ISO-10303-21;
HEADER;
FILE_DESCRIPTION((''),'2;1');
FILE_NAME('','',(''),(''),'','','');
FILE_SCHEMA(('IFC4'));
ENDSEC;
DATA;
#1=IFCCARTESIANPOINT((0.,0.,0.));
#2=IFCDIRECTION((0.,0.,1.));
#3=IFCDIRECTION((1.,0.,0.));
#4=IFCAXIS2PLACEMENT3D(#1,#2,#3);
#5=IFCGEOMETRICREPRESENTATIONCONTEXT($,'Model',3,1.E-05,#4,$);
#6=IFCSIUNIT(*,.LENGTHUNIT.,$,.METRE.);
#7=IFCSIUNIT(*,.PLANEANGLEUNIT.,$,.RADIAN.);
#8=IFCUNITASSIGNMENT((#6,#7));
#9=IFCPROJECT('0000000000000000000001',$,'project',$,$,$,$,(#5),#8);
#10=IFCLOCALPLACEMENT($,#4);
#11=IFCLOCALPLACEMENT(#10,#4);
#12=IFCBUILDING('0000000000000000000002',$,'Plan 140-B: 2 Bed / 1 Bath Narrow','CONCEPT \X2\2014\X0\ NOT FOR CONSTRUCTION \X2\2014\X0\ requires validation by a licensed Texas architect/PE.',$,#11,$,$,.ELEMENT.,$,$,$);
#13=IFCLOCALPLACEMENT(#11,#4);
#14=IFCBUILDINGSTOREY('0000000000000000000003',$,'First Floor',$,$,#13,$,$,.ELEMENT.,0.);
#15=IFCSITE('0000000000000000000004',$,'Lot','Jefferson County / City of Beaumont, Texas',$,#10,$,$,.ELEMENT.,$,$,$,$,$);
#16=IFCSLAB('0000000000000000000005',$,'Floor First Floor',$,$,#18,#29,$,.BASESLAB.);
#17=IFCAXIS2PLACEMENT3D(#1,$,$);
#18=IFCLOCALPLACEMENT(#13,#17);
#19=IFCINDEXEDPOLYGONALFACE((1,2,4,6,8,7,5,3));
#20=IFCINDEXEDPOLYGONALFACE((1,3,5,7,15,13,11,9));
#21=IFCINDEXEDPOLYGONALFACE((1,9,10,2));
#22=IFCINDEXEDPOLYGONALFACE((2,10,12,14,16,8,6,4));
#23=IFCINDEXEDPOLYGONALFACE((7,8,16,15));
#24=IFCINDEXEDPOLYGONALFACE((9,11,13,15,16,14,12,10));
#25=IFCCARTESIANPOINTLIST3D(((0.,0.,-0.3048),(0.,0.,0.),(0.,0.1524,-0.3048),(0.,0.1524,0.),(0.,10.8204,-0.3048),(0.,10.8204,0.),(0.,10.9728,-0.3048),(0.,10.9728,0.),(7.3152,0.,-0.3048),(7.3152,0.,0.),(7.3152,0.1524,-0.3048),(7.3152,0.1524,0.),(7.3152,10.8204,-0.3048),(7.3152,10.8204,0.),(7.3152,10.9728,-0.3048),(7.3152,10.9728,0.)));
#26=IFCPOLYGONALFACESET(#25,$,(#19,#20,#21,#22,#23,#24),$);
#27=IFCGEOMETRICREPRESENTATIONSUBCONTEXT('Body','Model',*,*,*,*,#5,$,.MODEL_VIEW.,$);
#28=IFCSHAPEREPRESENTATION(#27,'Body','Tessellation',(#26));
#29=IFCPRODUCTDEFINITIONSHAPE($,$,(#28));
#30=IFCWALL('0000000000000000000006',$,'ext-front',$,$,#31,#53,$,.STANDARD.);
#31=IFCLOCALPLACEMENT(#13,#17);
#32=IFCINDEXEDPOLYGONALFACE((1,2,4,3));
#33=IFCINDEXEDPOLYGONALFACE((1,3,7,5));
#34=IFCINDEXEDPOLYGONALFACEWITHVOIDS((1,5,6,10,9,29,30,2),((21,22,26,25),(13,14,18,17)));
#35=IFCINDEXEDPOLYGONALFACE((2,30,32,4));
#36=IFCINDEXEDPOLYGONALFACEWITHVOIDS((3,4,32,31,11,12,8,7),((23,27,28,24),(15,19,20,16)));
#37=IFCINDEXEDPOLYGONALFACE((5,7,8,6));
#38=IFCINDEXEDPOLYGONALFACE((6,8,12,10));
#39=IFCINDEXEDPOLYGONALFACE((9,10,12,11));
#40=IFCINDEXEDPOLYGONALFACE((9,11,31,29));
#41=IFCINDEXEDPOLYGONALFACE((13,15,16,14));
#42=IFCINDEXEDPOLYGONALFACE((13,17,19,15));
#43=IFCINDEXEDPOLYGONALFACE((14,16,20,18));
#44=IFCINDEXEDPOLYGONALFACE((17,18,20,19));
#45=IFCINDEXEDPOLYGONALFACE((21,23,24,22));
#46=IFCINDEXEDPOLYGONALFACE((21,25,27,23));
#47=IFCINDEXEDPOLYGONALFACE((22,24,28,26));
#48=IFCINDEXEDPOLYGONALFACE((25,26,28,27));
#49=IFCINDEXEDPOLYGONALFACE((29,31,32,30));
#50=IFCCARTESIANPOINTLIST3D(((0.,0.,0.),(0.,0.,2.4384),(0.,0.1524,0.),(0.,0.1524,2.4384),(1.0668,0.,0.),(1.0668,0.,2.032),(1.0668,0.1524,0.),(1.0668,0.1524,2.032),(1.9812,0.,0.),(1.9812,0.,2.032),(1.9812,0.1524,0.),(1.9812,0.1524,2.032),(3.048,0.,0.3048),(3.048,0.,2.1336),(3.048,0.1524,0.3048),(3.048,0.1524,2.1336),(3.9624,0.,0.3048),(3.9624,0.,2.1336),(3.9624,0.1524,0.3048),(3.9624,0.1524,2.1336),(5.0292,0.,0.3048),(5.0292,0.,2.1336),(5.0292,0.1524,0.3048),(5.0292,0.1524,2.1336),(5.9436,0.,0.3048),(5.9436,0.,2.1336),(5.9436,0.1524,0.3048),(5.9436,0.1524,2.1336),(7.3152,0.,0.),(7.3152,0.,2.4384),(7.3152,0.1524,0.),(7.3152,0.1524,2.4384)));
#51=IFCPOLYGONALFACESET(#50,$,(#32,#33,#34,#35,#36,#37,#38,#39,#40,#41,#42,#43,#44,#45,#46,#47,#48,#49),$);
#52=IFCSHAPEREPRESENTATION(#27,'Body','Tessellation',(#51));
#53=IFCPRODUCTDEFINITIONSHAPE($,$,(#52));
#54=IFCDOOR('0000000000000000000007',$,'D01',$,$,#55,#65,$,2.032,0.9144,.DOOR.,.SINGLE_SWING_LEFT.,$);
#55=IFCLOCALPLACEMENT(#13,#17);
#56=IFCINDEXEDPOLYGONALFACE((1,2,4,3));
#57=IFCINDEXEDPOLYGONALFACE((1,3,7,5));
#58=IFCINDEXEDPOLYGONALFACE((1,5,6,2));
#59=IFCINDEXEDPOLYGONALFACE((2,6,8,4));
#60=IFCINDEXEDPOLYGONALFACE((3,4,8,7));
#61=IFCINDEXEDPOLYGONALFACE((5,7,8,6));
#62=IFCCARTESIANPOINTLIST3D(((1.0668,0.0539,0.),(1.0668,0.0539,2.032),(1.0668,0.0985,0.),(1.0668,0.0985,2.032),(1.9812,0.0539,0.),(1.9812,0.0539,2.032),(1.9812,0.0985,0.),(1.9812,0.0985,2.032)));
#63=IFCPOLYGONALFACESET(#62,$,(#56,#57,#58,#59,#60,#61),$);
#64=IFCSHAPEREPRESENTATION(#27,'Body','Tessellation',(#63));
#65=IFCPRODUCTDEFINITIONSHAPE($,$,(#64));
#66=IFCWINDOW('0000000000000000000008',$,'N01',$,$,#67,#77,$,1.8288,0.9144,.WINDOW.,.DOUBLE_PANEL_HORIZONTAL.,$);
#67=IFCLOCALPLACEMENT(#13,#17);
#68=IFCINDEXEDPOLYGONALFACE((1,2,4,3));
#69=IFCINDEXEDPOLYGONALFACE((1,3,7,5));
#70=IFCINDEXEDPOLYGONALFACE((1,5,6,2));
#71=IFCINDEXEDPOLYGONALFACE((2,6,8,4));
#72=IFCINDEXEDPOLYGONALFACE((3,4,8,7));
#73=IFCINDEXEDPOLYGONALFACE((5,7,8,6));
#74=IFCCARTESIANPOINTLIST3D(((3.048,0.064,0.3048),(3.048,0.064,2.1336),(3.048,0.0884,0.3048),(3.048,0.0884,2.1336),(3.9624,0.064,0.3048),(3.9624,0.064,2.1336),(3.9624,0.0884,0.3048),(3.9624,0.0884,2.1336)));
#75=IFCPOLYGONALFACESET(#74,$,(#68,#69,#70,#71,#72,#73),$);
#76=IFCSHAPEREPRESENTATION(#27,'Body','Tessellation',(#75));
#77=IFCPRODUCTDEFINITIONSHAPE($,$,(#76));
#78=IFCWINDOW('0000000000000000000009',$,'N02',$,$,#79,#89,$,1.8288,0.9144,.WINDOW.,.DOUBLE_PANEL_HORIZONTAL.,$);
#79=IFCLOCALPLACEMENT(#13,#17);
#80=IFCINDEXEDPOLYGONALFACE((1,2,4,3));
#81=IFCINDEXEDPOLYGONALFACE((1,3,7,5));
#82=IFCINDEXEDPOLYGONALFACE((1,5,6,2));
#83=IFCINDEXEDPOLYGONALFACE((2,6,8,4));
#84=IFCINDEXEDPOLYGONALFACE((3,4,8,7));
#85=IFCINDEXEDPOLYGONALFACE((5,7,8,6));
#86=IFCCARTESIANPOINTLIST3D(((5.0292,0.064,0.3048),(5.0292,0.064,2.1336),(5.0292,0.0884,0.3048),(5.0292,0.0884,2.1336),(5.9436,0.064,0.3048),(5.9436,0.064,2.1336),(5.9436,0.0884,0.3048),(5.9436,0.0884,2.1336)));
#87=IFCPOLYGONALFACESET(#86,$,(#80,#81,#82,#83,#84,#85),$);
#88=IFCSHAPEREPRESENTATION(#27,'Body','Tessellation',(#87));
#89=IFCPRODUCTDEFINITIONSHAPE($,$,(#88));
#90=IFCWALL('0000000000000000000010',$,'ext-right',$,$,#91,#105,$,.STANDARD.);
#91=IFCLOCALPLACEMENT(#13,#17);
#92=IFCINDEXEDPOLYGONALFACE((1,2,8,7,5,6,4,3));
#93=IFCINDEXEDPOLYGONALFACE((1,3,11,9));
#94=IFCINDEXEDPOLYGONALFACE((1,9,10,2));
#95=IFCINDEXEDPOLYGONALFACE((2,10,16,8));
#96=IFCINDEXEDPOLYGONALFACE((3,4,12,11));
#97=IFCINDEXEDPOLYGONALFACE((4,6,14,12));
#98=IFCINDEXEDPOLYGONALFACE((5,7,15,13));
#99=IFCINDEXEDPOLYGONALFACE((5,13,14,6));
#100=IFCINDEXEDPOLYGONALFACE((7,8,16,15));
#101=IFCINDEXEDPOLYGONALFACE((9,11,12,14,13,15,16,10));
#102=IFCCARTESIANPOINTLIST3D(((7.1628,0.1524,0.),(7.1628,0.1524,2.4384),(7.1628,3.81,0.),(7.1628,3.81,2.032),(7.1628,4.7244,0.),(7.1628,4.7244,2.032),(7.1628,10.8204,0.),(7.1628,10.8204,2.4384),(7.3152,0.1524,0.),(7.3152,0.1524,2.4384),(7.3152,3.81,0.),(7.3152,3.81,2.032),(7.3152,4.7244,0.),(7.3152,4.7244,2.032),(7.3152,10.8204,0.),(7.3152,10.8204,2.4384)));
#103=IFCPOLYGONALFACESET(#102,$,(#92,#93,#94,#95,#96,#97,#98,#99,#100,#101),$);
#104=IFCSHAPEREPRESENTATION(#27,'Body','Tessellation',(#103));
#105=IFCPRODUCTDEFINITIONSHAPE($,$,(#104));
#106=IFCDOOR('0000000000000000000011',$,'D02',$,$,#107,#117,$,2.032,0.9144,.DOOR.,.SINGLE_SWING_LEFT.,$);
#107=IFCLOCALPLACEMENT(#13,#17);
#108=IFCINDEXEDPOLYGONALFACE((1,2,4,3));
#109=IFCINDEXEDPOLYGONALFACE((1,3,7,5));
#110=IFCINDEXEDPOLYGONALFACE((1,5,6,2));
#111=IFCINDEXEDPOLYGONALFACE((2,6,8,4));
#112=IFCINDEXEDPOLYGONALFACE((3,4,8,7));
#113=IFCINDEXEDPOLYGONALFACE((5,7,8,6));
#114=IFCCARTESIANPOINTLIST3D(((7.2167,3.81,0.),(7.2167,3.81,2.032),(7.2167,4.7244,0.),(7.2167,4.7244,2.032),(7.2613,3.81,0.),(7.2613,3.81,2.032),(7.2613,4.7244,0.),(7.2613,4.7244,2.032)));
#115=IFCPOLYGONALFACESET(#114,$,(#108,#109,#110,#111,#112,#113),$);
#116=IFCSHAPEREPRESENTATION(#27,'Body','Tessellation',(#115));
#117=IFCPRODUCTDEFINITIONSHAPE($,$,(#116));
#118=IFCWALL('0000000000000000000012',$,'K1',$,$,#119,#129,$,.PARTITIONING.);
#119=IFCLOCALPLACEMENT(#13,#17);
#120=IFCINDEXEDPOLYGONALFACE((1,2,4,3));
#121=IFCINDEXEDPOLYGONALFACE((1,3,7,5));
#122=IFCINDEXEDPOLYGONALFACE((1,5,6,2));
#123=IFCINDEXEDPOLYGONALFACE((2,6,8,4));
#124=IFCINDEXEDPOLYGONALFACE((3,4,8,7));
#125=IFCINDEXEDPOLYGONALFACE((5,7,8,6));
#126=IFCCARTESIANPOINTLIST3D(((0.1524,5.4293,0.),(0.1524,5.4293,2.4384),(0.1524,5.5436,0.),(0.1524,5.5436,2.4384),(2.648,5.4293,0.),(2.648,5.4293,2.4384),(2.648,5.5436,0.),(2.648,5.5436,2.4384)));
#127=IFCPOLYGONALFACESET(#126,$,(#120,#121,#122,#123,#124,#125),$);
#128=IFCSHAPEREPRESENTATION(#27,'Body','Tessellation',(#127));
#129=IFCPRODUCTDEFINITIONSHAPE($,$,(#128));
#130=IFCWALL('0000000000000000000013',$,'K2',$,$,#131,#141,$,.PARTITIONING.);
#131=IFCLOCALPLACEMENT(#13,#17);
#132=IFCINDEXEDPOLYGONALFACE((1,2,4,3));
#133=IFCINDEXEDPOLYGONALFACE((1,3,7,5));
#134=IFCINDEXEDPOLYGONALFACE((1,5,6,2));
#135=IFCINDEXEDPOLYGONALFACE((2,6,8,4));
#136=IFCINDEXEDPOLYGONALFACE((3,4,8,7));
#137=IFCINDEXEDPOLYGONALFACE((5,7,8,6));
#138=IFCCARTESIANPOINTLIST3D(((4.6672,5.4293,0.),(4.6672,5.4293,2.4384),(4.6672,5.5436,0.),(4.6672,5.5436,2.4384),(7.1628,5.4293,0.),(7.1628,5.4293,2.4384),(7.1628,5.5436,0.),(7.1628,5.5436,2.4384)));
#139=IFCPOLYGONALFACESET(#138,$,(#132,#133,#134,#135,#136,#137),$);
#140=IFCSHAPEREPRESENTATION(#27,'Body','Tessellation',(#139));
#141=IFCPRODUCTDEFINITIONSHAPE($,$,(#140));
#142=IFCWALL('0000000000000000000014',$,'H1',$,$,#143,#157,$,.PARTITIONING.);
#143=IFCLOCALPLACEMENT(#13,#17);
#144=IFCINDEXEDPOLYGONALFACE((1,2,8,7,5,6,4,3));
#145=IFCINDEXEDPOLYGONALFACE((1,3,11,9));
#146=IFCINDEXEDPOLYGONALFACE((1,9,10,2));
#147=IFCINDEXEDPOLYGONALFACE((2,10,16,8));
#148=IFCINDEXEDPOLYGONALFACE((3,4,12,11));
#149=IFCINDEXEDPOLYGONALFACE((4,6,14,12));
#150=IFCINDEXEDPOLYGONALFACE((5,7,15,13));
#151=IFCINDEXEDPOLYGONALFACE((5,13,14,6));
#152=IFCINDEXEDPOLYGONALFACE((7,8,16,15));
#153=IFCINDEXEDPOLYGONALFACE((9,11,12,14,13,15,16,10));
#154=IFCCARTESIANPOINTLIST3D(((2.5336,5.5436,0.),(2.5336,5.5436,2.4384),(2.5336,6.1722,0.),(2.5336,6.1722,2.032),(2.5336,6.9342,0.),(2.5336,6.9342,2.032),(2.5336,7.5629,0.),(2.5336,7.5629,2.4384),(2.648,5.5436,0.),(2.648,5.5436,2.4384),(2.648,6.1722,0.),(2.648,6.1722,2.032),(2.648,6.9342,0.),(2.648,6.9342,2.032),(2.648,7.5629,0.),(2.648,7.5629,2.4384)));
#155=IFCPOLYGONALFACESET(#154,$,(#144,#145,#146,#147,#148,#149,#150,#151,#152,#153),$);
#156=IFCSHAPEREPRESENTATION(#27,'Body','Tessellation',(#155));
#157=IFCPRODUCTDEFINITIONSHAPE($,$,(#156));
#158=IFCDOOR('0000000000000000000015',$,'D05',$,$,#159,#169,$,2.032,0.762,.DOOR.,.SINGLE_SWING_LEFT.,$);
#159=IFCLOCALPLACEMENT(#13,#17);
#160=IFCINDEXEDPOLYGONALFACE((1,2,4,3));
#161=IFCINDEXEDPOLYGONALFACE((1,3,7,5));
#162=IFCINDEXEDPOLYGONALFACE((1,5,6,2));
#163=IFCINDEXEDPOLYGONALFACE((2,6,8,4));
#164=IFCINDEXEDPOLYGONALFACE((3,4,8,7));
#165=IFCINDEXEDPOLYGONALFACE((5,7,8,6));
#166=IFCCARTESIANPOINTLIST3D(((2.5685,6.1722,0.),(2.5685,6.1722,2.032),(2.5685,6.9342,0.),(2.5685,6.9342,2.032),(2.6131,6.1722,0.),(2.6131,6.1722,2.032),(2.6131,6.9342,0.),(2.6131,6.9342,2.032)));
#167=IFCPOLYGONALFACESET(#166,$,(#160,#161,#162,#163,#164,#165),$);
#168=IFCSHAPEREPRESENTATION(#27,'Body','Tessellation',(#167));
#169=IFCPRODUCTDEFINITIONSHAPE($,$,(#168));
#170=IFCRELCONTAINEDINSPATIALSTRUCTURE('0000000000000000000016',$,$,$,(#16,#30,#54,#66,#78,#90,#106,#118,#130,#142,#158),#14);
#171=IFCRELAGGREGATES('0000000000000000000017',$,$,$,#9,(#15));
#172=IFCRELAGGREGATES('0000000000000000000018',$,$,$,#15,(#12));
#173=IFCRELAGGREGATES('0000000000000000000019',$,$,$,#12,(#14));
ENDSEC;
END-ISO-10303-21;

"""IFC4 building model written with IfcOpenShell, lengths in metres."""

from ifc_helpers import new_model, si_unit, frame, frame_2d, origin_with_axes, place, context, subcontext, project, spatial, polyline, rectangle, outline, extrude, element, fill, save


model = new_model("IFC4")

# Units and contexts
model_context = context("Model", 3, precision=1e-05, world=origin_with_axes())
body_context = subcontext(model_context, "Body", "Model", "MODEL_VIEW")
ifc_project = project(units=[si_unit("LENGTHUNIT", "METRE"), si_unit("PLANEANGLEUNIT", "RADIAN")], contexts=[model_context])

# Site, building, storey
site_placement = place(None, origin_with_axes())
site = spatial("IfcSite", under=ifc_project, at=site_placement, Name="Lot", Description="Jefferson County / City of Beaumont, Texas", CompositionType="ELEMENT")
building_placement = place(site_placement, origin_with_axes())
building = spatial("IfcBuilding", under=site, at=building_placement, Name="Plan 140-B: 2 Bed / 1 Bath Narrow", Description="CONCEPT — NOT FOR CONSTRUCTION — requires validation by a licensed Texas architect/PE.", CompositionType="ELEMENT")
storey_placement = place(building_placement, origin_with_axes())
storey = spatial("IfcBuildingStorey", under=building, at=storey_placement, Name="First Floor", CompositionType="ELEMENT", Elevation=0.0)

# Slab
slab_placement = place(storey_placement, frame((0.0, 0.0, -0.3048), z_axis=(0.0, 0.0, 1.0), x_axis=(1.0, 0.0, 0.0)))
element("IfcSlab", 1, at=slab_placement, inside=storey, Name="Floor First Floor", PredefinedType="BASESLAB", context=body_context, shape_type="SweptSolid", body=[
    extrude(outline(polyline([(0.0, 10.9728), (7.3152, 10.9728), (7.3152, 10.8204), (7.3152, 0.1524), (7.3152, 0.0), (0.0, 0.0), (0.0, 0.1524), (0.0, 10.8204), (0.0, 10.9728)])), origin_with_axes(), (0.0, 0.0, 1.0), 0.3048),
])

# Wall, openings, door, windows
wall_1_placement = place(storey_placement, frame((0.0, 0.0762, 0.0), z_axis=(0.0, 0.0, 1.0), x_axis=(1.0, 0.0, 0.0)))
wall_1 = element("IfcWall", 2, at=wall_1_placement, inside=storey, Name="ext-front", PredefinedType="STANDARD", context=body_context, shape_type="SweptSolid", body=[
    extrude(rectangle(XDim=7.3152, YDim=0.1524, at=frame_2d((3.6576, 0.0), x_axis=(1.0, 0.0))), origin_with_axes(), (0.0, 0.0, 1.0), 2.4384),
])
opening_1_placement = place(wall_1_placement, frame((1.0668, 0.0, 0.0), z_axis=(0.0, 0.0, 1.0), x_axis=(1.0, 0.0, 0.0)))
opening_1 = element("IfcOpeningElement", 3, at=opening_1_placement, cuts=wall_1, PredefinedType="OPENING", context=body_context, shape_type="SweptSolid", body=[
    extrude(rectangle(XDim=0.9144, YDim=0.1829, at=frame_2d((0.4572, 0.0), x_axis=(1.0, 0.0))), origin_with_axes(), (0.0, 0.0, 1.0), 2.032),
])
opening_2_placement = place(wall_1_placement, frame((3.048, 0.0, 0.3048), z_axis=(0.0, 0.0, 1.0), x_axis=(1.0, 0.0, 0.0)))
opening_2 = element("IfcOpeningElement", 4, at=opening_2_placement, cuts=wall_1, PredefinedType="OPENING", context=body_context, shape_type="SweptSolid", body=[
    extrude(rectangle(XDim=0.9144, YDim=0.1829, at=frame_2d((0.4572, 0.0), x_axis=(1.0, 0.0))), origin_with_axes(), (0.0, 0.0, 1.0), 1.8288),
])
opening_3_placement = place(wall_1_placement, frame((5.0292, 0.0, 0.3048), z_axis=(0.0, 0.0, 1.0), x_axis=(1.0, 0.0, 0.0)))
opening_3 = element("IfcOpeningElement", 5, at=opening_3_placement, cuts=wall_1, PredefinedType="OPENING", context=body_context, shape_type="SweptSolid", body=[
    extrude(rectangle(XDim=0.9144, YDim=0.1829, at=frame_2d((0.4572, 0.0), x_axis=(1.0, 0.0))), origin_with_axes(), (0.0, 0.0, 1.0), 1.8288),
])
door_1_placement = place(opening_1_placement, origin_with_axes())
door_1 = element("IfcDoor", 6, at=door_1_placement, inside=storey, Name="D01", OperationType="SINGLE_SWING_LEFT", OverallHeight=2.032, OverallWidth=0.9144, PredefinedType="DOOR", context=body_context, shape_type="SweptSolid", body=[
    extrude(rectangle(XDim=0.9144, YDim=0.0445, at=frame_2d((0.4572, 0.0), x_axis=(1.0, 0.0))), origin_with_axes(), (0.0, 0.0, 1.0), 2.032),
])
fill(opening_1, door_1)
window_1_placement = place(opening_2_placement, origin_with_axes())
window_1 = element("IfcWindow", 7, at=window_1_placement, inside=storey, Name="N01", OverallHeight=1.8288, OverallWidth=0.9144, PartitioningType="DOUBLE_PANEL_HORIZONTAL", PredefinedType="WINDOW", context=body_context, shape_type="SweptSolid", body=[
    extrude(rectangle(XDim=0.9144, YDim=0.0244, at=frame_2d((0.4572, 0.0), x_axis=(1.0, 0.0))), origin_with_axes(), (0.0, 0.0, 1.0), 1.8288),
])
fill(opening_2, window_1)
window_2_placement = place(opening_3_placement, origin_with_axes())
window_2 = element("IfcWindow", 8, at=window_2_placement, inside=storey, Name="N02", OverallHeight=1.8288, OverallWidth=0.9144, PartitioningType="DOUBLE_PANEL_HORIZONTAL", PredefinedType="WINDOW", context=body_context, shape_type="SweptSolid", body=[
    extrude(rectangle(XDim=0.9144, YDim=0.0244, at=frame_2d((0.4572, 0.0), x_axis=(1.0, 0.0))), origin_with_axes(), (0.0, 0.0, 1.0), 1.8288),
])
fill(opening_3, window_2)

# Wall, opening, door
wall_2_placement = place(storey_placement, frame((7.239, 0.1524, 0.0), z_axis=(0.0, 0.0, 1.0), x_axis=(0.0, 1.0, 0.0)))
wall_2 = element("IfcWall", 9, at=wall_2_placement, inside=storey, Name="ext-right", PredefinedType="STANDARD", context=body_context, shape_type="SweptSolid", body=[
    extrude(rectangle(XDim=10.668, YDim=0.1524, at=frame_2d((5.334, 0.0), x_axis=(1.0, 0.0))), origin_with_axes(), (0.0, 0.0, 1.0), 2.4384),
])
opening_4_placement = place(wall_2_placement, frame((3.6576, 0.0, 0.0), z_axis=(0.0, 0.0, 1.0), x_axis=(1.0, 0.0, 0.0)))
opening_4 = element("IfcOpeningElement", 10, at=opening_4_placement, cuts=wall_2, PredefinedType="OPENING", context=body_context, shape_type="SweptSolid", body=[
    extrude(rectangle(XDim=0.9144, YDim=0.1829, at=frame_2d((0.4572, 0.0), x_axis=(1.0, 0.0))), origin_with_axes(), (0.0, 0.0, 1.0), 2.032),
])
door_2_placement = place(opening_4_placement, origin_with_axes())
door_2 = element("IfcDoor", 11, at=door_2_placement, inside=storey, Name="D02", OperationType="SINGLE_SWING_LEFT", OverallHeight=2.032, OverallWidth=0.9144, PredefinedType="DOOR", context=body_context, shape_type="SweptSolid", body=[
    extrude(rectangle(XDim=0.9144, YDim=0.0445, at=frame_2d((0.4572, 0.0), x_axis=(1.0, 0.0))), origin_with_axes(), (0.0, 0.0, 1.0), 2.032),
])
fill(opening_4, door_2)

# Walls
for number, where, z_axis, x_axis, name in (
    (12, (0.1524, 5.4864, 0.0), (0.0, 0.0, 1.0), (1.0, 0.0, 0.0), "K1"),
    (13, (4.6673, 5.4864, 0.0), (0.0, 0.0, 1.0), (1.0, 0.0, 0.0), "K2"),
):
    element("IfcWall", number, at=place(storey_placement, frame(where, z_axis=z_axis, x_axis=x_axis)), inside=storey, Name=name, PredefinedType="PARTITIONING", context=body_context, shape_type="SweptSolid", body=[
        extrude(rectangle(XDim=2.4956, YDim=0.1143, at=frame_2d((1.2478, 0.0), x_axis=(1.0, 0.0))), origin_with_axes(), (0.0, 0.0, 1.0), 2.4384),
    ])

# Wall, opening, door
wall_3_placement = place(storey_placement, frame((2.5908, 5.5436, 0.0), z_axis=(0.0, 0.0, 1.0), x_axis=(0.0, 1.0, 0.0)))
wall_3 = element("IfcWall", 14, at=wall_3_placement, inside=storey, Name="H1", PredefinedType="PARTITIONING", context=body_context, shape_type="SweptSolid", body=[
    extrude(rectangle(XDim=2.0193, YDim=0.1143, at=frame_2d((1.0097, 0.0), x_axis=(1.0, 0.0))), origin_with_axes(), (0.0, 0.0, 1.0), 2.4384),
])
opening_5_placement = place(wall_3_placement, frame((0.6287, 0.0, 0.0), z_axis=(0.0, 0.0, 1.0), x_axis=(1.0, 0.0, 0.0)))
opening_5 = element("IfcOpeningElement", 15, at=opening_5_placement, cuts=wall_3, PredefinedType="OPENING", context=body_context, shape_type="SweptSolid", body=[
    extrude(rectangle(XDim=0.762, YDim=0.1448, at=frame_2d((0.381, 0.0), x_axis=(1.0, 0.0))), origin_with_axes(), (0.0, 0.0, 1.0), 2.032),
])
door_3_placement = place(opening_5_placement, origin_with_axes())
door_3 = element("IfcDoor", 16, at=door_3_placement, inside=storey, Name="D05", OperationType="SINGLE_SWING_LEFT", OverallHeight=2.032, OverallWidth=0.762, PredefinedType="DOOR", context=body_context, shape_type="SweptSolid", body=[
    extrude(rectangle(XDim=0.762, YDim=0.0445, at=frame_2d((0.381, 0.0), x_axis=(1.0, 0.0))), origin_with_axes(), (0.0, 0.0, 1.0), 2.032),
])
fill(opening_5, door_3)

save(model, "model.ifc")
